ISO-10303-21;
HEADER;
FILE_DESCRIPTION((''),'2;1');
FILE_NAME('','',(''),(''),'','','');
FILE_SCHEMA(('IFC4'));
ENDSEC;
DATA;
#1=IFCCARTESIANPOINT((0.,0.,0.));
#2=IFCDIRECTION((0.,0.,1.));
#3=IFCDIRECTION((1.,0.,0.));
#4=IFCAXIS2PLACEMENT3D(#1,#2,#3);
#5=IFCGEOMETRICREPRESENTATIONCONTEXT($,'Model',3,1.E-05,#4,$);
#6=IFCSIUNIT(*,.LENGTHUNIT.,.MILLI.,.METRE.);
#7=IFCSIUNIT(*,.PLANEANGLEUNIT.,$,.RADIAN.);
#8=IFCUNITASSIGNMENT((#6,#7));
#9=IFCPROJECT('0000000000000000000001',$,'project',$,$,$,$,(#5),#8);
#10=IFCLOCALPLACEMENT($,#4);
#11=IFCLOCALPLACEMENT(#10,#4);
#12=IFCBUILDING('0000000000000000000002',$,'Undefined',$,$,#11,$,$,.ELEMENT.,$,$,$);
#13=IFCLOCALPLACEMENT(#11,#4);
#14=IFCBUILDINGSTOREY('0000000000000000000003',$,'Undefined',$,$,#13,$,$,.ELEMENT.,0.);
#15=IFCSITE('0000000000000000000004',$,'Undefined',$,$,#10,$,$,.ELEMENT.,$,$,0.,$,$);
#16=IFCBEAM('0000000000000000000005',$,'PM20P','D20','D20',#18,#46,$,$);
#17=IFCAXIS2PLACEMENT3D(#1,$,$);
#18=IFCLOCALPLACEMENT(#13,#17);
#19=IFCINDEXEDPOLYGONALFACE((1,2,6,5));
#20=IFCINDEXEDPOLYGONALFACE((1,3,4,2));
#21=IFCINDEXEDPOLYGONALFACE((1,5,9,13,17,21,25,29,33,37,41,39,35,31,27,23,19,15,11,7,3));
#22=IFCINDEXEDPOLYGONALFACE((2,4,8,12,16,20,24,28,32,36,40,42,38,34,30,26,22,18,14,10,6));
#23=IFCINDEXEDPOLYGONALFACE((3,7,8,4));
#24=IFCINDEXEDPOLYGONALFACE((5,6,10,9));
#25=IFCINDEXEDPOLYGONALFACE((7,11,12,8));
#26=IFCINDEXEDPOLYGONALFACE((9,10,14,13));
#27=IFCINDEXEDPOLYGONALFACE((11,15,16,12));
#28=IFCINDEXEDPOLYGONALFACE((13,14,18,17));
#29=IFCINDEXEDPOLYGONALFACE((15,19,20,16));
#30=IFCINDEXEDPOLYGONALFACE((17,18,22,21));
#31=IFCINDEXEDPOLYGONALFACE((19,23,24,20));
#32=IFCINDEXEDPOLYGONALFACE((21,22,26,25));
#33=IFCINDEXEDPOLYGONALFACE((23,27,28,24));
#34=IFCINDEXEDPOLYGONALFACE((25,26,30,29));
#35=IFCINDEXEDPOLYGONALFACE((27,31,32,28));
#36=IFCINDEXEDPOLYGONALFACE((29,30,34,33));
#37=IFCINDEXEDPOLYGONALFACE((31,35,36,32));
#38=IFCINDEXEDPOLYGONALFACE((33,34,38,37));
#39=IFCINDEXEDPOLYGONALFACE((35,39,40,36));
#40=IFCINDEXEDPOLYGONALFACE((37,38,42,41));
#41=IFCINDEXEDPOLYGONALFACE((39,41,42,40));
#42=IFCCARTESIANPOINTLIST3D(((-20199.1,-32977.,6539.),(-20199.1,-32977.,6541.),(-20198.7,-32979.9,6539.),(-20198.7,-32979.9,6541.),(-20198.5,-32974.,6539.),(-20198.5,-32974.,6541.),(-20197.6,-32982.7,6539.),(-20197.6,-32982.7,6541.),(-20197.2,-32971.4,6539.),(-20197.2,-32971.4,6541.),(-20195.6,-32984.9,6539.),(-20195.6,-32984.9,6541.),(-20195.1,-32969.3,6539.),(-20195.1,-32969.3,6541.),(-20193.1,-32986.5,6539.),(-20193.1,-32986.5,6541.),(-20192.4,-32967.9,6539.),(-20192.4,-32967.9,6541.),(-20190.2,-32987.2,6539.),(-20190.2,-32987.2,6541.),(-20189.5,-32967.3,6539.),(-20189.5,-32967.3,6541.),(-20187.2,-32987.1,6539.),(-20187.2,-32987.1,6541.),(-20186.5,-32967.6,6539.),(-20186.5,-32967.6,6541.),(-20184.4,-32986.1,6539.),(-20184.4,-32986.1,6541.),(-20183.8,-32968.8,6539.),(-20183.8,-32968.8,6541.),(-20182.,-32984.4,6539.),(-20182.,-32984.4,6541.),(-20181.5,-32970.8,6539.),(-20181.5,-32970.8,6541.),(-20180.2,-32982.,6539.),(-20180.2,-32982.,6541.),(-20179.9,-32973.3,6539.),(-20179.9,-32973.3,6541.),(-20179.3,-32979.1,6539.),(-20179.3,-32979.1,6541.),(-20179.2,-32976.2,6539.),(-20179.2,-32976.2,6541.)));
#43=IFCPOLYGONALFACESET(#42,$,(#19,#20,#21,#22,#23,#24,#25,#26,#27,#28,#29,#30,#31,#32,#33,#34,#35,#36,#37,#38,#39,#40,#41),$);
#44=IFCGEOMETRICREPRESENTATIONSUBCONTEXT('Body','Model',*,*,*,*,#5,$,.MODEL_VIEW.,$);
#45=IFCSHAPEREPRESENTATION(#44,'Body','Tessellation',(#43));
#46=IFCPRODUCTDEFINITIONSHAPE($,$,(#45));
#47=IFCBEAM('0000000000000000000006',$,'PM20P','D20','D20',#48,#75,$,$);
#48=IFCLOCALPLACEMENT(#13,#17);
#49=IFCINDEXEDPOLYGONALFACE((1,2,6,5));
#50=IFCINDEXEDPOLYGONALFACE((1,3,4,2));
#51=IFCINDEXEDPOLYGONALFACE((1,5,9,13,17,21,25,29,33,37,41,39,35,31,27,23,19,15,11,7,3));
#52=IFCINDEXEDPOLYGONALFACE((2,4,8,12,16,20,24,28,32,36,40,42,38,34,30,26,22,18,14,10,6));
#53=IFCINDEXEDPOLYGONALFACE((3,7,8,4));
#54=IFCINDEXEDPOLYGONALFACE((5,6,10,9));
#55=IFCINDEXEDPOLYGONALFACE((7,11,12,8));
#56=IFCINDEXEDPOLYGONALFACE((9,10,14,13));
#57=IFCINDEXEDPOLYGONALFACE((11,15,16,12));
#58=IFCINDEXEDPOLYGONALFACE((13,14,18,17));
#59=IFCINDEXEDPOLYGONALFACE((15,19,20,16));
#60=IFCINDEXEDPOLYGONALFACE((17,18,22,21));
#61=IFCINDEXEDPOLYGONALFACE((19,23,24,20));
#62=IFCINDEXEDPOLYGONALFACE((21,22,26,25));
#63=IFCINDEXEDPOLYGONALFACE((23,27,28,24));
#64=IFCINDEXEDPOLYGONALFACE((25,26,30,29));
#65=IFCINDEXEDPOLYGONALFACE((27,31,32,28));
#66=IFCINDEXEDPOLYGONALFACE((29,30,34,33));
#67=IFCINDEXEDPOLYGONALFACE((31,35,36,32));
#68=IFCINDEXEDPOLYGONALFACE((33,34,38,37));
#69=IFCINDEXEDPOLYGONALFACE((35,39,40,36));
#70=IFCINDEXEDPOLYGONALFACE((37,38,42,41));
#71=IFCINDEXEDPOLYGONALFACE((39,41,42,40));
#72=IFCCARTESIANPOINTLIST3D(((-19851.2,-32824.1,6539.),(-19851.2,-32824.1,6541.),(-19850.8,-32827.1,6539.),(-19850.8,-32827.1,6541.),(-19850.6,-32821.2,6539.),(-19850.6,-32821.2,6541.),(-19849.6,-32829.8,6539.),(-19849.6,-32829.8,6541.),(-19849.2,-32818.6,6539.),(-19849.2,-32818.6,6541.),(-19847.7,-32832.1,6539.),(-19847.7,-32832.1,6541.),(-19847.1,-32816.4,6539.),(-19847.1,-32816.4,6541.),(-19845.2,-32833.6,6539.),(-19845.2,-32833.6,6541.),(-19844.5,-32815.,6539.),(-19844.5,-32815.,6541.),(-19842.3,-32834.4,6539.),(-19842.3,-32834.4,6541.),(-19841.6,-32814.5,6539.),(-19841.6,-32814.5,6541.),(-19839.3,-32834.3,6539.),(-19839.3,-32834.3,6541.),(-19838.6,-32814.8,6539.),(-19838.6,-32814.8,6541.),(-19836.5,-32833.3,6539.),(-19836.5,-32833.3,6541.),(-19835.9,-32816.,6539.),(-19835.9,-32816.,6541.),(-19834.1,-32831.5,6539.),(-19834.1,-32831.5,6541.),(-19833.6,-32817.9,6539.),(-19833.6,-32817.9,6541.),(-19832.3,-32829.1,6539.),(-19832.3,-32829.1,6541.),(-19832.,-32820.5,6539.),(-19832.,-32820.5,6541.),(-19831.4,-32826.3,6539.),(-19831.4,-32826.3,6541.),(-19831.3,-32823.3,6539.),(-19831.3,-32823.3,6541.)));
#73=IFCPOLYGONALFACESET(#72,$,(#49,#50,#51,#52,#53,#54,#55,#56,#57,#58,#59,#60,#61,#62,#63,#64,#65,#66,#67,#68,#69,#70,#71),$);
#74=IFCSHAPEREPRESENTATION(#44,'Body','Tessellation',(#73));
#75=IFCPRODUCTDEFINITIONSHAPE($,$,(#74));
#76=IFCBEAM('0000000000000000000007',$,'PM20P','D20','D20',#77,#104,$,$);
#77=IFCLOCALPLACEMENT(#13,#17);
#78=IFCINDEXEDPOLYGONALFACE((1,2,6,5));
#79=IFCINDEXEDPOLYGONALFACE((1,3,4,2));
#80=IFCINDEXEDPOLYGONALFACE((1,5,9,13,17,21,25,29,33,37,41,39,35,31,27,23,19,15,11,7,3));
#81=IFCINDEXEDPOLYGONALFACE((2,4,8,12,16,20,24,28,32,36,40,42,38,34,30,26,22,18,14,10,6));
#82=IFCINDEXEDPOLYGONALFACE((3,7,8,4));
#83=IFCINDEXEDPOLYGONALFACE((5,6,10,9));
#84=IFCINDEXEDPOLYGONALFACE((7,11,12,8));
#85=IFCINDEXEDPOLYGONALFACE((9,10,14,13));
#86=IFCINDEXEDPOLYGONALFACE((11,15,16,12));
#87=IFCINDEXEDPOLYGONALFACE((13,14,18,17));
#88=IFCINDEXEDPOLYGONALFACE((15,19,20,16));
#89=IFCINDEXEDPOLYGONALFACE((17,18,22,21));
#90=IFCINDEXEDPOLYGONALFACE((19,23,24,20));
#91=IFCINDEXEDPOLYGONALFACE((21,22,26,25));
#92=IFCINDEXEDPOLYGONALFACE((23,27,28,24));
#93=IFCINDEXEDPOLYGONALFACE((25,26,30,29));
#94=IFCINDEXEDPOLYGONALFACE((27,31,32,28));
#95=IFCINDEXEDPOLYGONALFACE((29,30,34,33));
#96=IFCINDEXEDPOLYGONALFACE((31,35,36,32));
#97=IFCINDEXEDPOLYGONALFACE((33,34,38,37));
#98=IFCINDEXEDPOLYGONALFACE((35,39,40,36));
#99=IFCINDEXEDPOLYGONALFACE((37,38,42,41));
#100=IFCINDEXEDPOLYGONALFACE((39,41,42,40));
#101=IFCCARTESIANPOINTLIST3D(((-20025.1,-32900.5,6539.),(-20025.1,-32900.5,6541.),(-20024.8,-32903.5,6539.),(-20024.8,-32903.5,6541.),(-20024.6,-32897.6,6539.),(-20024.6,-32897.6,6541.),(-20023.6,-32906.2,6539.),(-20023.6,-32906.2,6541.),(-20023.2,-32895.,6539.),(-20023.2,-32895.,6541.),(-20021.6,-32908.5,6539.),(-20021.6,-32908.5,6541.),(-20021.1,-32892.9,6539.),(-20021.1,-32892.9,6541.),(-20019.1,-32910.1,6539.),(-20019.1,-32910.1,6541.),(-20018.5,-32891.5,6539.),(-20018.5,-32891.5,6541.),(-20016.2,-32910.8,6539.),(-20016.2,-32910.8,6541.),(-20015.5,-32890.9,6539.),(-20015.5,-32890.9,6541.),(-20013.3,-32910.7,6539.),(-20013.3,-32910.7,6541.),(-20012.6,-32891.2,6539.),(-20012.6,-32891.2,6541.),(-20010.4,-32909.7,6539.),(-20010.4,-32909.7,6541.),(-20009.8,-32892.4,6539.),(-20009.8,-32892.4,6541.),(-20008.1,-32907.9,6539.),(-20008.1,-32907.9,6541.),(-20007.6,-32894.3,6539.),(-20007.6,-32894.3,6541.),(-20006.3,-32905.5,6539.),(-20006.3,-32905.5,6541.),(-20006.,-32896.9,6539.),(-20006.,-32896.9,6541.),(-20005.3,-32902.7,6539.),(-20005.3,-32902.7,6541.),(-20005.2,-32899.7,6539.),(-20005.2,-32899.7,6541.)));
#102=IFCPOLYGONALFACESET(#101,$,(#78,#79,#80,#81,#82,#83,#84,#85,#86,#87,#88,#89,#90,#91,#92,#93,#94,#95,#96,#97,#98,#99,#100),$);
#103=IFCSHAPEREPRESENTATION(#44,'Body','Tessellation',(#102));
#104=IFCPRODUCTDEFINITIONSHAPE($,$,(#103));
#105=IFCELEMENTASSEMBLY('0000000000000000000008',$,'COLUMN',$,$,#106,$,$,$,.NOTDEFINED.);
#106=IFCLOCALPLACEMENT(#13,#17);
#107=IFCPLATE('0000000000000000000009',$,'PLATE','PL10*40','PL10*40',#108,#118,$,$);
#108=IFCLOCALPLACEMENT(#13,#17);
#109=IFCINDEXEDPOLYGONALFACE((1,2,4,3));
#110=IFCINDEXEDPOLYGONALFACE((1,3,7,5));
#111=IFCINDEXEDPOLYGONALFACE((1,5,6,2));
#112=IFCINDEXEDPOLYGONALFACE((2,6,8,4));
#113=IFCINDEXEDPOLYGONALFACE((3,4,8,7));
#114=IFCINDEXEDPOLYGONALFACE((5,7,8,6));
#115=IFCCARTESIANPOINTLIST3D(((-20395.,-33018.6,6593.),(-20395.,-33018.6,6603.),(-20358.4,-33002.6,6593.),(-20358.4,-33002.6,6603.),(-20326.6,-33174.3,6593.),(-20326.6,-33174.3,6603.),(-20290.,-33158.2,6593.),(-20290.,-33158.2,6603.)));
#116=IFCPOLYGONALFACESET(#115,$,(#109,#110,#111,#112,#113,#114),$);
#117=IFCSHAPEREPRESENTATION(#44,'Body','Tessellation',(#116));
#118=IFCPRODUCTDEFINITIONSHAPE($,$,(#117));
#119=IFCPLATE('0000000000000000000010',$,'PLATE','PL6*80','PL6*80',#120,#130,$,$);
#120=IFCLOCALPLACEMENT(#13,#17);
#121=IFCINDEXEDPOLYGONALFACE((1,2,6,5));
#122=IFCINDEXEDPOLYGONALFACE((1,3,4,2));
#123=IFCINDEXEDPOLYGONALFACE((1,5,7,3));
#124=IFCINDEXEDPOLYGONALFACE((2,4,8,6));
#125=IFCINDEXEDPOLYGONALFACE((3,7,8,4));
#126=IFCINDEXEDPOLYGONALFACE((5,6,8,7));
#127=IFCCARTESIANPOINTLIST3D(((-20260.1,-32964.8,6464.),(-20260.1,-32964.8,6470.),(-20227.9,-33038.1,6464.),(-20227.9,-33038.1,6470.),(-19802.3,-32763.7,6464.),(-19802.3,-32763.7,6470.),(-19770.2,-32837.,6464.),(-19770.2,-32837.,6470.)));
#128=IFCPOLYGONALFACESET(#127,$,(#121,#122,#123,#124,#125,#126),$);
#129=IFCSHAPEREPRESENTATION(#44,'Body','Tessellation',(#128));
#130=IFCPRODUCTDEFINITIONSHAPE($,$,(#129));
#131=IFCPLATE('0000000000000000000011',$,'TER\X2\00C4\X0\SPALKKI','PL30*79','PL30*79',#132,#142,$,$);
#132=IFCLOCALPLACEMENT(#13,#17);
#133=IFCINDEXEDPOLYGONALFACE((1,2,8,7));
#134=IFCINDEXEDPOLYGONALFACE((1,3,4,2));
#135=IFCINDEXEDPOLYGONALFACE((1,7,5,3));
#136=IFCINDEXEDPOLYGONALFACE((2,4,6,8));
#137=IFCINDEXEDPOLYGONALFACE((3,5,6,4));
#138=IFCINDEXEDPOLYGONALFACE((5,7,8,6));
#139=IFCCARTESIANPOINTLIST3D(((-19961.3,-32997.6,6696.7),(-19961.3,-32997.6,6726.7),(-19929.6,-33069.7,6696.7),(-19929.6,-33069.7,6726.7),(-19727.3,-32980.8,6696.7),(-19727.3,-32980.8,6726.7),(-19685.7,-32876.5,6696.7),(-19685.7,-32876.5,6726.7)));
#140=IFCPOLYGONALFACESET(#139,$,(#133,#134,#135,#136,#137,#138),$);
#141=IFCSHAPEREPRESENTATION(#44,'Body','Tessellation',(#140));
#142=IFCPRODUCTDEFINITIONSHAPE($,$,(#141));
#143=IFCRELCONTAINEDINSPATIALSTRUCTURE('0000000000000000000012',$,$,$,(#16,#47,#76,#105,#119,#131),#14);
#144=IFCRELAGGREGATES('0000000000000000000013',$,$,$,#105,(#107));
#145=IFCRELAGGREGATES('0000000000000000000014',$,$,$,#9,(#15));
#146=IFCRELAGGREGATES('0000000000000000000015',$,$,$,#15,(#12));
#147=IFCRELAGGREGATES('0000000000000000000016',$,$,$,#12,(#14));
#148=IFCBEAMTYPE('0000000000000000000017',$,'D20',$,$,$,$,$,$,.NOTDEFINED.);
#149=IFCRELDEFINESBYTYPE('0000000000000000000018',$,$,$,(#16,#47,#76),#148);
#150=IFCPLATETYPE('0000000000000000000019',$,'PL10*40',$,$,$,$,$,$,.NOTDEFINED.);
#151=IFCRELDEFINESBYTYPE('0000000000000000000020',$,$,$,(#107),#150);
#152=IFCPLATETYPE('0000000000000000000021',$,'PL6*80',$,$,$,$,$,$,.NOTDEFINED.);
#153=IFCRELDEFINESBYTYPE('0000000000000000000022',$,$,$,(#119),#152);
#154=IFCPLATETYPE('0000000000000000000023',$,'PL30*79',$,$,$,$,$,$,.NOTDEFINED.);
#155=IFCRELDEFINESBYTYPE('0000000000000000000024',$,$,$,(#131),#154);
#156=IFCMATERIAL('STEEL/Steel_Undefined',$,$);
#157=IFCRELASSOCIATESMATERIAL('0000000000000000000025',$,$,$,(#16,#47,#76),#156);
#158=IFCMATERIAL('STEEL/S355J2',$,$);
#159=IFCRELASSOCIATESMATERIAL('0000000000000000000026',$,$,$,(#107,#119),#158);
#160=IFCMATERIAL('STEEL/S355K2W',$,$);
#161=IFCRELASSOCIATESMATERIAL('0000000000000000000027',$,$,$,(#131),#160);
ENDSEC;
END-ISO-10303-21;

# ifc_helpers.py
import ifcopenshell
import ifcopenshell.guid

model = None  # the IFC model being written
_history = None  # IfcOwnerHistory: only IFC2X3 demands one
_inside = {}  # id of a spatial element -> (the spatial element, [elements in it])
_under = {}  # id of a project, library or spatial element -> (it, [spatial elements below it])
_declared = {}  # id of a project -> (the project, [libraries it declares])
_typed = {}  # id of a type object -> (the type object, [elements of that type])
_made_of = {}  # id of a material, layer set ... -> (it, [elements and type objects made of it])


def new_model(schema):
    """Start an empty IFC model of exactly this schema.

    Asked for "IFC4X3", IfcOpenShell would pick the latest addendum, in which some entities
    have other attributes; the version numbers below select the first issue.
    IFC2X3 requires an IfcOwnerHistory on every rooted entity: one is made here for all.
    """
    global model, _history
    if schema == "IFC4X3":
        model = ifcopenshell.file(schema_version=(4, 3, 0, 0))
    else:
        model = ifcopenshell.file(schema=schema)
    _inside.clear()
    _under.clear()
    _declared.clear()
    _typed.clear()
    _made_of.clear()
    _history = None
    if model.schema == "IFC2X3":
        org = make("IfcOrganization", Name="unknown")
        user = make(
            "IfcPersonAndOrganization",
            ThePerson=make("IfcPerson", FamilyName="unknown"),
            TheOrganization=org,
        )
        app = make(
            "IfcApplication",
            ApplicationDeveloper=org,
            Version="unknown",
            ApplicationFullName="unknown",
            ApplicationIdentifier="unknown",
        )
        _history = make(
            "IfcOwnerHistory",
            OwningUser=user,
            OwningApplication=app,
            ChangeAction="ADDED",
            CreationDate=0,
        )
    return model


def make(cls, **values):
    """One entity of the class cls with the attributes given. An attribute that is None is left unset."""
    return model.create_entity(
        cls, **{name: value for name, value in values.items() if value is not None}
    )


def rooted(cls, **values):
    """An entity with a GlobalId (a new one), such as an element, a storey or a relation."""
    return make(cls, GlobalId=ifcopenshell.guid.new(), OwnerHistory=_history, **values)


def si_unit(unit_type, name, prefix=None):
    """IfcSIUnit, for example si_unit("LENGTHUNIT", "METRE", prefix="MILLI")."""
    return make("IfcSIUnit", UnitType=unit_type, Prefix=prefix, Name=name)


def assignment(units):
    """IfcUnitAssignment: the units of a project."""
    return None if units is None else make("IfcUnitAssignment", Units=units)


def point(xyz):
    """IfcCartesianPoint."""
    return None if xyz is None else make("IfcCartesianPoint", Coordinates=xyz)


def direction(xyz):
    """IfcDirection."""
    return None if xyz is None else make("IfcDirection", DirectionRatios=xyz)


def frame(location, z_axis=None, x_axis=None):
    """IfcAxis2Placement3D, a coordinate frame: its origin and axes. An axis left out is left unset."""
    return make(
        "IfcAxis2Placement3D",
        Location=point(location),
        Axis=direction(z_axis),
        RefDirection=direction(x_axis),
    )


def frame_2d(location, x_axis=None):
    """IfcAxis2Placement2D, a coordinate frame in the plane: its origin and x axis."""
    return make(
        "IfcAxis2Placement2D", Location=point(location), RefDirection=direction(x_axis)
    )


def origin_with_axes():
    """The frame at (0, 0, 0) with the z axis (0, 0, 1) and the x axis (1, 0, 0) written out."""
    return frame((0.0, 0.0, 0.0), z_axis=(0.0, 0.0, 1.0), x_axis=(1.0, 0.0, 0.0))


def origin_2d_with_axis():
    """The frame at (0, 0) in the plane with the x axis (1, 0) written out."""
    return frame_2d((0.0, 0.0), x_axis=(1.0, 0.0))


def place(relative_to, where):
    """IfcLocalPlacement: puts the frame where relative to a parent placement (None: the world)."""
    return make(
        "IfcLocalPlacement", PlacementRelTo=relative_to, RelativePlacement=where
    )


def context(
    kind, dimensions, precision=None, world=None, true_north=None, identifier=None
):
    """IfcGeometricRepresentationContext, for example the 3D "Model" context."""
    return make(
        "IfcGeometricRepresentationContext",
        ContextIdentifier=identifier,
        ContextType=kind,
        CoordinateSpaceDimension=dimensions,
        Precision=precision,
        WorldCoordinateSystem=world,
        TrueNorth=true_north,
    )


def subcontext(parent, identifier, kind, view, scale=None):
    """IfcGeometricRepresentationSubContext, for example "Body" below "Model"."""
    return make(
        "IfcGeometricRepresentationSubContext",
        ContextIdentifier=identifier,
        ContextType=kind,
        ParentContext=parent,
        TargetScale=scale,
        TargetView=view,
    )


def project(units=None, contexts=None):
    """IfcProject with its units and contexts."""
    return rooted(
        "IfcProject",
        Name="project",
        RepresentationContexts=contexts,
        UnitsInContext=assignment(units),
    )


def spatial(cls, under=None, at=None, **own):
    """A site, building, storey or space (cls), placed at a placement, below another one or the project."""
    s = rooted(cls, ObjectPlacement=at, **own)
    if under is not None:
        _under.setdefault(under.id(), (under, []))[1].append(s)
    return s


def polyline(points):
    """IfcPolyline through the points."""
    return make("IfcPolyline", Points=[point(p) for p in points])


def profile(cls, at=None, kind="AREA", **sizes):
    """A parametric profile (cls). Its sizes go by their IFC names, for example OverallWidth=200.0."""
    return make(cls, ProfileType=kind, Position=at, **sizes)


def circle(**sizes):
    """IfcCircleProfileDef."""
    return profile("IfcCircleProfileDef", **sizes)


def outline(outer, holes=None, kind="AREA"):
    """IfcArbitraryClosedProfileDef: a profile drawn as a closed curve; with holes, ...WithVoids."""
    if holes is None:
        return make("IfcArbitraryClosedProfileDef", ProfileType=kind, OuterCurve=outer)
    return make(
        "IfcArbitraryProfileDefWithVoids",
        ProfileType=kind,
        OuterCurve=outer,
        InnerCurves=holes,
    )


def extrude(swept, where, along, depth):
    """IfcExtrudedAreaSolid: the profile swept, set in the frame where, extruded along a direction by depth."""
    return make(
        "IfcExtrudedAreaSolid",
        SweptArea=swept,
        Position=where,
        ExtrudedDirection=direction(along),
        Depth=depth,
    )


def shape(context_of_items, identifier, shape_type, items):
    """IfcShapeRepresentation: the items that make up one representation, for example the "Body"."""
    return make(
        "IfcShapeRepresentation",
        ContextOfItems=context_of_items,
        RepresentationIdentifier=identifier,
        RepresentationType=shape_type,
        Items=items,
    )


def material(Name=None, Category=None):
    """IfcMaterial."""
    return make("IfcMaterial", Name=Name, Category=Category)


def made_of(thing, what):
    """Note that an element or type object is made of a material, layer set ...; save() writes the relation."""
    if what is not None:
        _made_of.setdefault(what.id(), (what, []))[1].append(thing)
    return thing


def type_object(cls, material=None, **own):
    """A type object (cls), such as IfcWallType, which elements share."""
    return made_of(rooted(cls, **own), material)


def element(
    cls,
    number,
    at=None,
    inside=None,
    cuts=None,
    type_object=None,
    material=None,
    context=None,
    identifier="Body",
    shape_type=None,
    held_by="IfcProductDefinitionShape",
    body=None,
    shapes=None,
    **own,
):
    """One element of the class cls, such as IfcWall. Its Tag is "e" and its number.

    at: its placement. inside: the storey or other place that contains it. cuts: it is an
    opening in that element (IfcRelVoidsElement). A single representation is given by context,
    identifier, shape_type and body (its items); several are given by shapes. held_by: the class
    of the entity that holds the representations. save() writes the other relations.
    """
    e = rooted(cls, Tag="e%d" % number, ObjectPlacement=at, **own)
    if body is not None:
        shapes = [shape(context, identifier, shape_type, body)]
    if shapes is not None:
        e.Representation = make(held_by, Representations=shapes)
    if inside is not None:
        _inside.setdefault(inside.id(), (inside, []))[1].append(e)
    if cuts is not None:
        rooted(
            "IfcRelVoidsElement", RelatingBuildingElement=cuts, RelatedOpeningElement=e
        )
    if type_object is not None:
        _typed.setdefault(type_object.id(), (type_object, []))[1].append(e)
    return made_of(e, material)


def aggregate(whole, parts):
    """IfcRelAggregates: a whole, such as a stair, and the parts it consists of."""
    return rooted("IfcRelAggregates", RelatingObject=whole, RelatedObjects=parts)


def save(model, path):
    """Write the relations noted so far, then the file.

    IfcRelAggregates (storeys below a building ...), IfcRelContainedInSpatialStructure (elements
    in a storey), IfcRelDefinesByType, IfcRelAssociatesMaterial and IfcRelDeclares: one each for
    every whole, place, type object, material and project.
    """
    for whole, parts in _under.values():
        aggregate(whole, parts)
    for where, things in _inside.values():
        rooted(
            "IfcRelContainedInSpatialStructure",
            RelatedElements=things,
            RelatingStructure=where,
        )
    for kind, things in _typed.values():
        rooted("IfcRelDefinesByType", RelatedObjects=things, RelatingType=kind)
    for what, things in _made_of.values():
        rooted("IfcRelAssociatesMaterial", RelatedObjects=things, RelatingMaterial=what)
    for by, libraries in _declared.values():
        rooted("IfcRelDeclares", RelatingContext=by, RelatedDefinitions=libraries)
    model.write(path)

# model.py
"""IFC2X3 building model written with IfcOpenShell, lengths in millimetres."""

from ifc_helpers import new_model, si_unit, frame, origin_with_axes, origin_2d_with_axis, place, context, subcontext, project, spatial, polyline, circle, outline, extrude, material, type_object, element, aggregate, save


model = new_model("IFC2X3")

# Units and contexts
model_context = context("Model", 3, precision=1e-05, world=origin_with_axes())
body_context = subcontext(model_context, "Body", "Model", "MODEL_VIEW")
ifc_project = project(units=[si_unit("LENGTHUNIT", "METRE", prefix="MILLI"), si_unit("PLANEANGLEUNIT", "RADIAN")], contexts=[model_context])

# Site, building, storey
site_placement = place(None, origin_with_axes())
site = spatial("IfcSite", under=ifc_project, at=site_placement, Name="Undefined", CompositionType="ELEMENT", RefElevation=0.0)
building_placement = place(site_placement, origin_with_axes())
building = spatial("IfcBuilding", under=site, at=building_placement, Name="Undefined", CompositionType="ELEMENT")
storey_placement = place(building_placement, origin_with_axes())
storey = spatial("IfcBuildingStorey", under=building, at=storey_placement, Name="Undefined", CompositionType="ELEMENT", Elevation=0.0)

# Beams
ifc_material_1 = material(Name="STEEL/Steel_Undefined")
beam_type_1 = type_object("IfcBeamType", Name="D20", PredefinedType="NOTDEFINED")
for number, where, z_axis, x_axis, name in (
    (1, (-20189.1, -32977.3, 6541.0), (-0.402199, 0.915552, 0.0), (0.0, 0.0, -1.0), "PM20P"),
    (2, (-19841.2, -32824.5, 6541.0), (-0.402199, 0.915552, 0.0), (0.0, 0.0, -1.0), "PM20P"),
    (3, (-20015.1, -32900.9, 6541.0), (-0.402199, 0.915552, 0.0), (0.0, 0.0, -1.0), "PM20P"),
):
    element("IfcBeam", number, at=place(storey_placement, frame(where, z_axis=z_axis, x_axis=x_axis)), inside=storey, type_object=beam_type_1, material=ifc_material_1, Name=name, Description="D20", ObjectType="D20", context=body_context, shape_type="SweptSolid", body=[
        extrude(circle(Radius=10.0, at=origin_2d_with_axis()), frame((2.0, 0.0, 0.0), z_axis=(-1.0, 0.0, 0.0), x_axis=(0.0, -1.0, 0.0)), (0.0, 0.0, 1.0), 2.0),
    ])

# Element assembly, plate
assembly_placement = place(storey_placement, frame((-20342.6, -33088.4, 6133.0), z_axis=(-0.736465, 0.676475, 0.0), x_axis=(0.0, 0.0, 1.0)))
assembly = element("IfcElementAssembly", 4, at=assembly_placement, inside=storey, Name="COLUMN", PredefinedType="NOTDEFINED")
ifc_material_2 = material(Name="STEEL/S355J2")
plate_type_1 = type_object("IfcPlateType", Name="PL10*40", PredefinedType="NOTDEFINED")
plate_1_placement = place(storey_placement, frame((-20395.0, -33018.6, 6598.0), z_axis=(0.0, 0.0, 1.0), x_axis=(0.402197, -0.915553, 0.0)))
plate_1 = element("IfcPlate", 5, at=plate_1_placement, type_object=plate_type_1, material=ifc_material_2, Name="PLATE", Description="PL10*40", ObjectType="PL10*40", context=body_context, shape_type="SweptSolid", body=[
    extrude(outline(polyline([(0.0, 0.0), (170.0, 0.0), (170.0, 40.0), (0.0, 40.0), (0.0, 0.0)])), frame((0.0, 0.0, -5.0), z_axis=(0.0, 0.0, 1.0), x_axis=(1.0, 0.0, 0.0)), (0.0, 0.0, 1.0), 10.0),
])
aggregate(assembly, [plate_1])

# Plates
plate_type_2 = type_object("IfcPlateType", Name="PL6*80", PredefinedType="NOTDEFINED")
plate_2_placement = place(storey_placement, frame((-20260.1, -32964.8, 6467.0), z_axis=(0.0, 0.0, 1.0), x_axis=(0.402199, -0.915552, 0.0)))
element("IfcPlate", 6, at=plate_2_placement, inside=storey, type_object=plate_type_2, material=ifc_material_2, Name="PLATE", Description="PL6*80", ObjectType="PL6*80", context=body_context, shape_type="SweptSolid", body=[
    extrude(outline(polyline([(0.0, 0.0), (80.0, 0.0), (80.0, 500.0), (0.0, 500.0), (0.0, 0.0)])), frame((0.0, 0.0, -3.0), z_axis=(0.0, 0.0, 1.0), x_axis=(1.0, 0.0, 0.0)), (0.0, 0.0, 1.0), 6.0),
])
ifc_material_3 = material(Name="STEEL/S355K2W")
plate_type_3 = type_object("IfcPlateType", Name="PL30*79", PredefinedType="NOTDEFINED")
plate_3_placement = place(storey_placement, frame((-19929.6, -33069.7, 6711.7), z_axis=(0.0, 0.0, 1.0), x_axis=(0.915556, 0.40219, 0.0)))
element("IfcPlate", 7, at=plate_3_placement, inside=storey, type_object=plate_type_3, material=ifc_material_3, Name="TERÄSPALKKI", Description="PL30*79", ObjectType="PL30*79", context=body_context, shape_type="SweptSolid", body=[
    extrude(outline(polyline([(0.0, 0.0), (221.0, 0.0), (301.0, 78.7), (0.0, 78.7), (0.0, 0.0)])), frame((0.0, 0.0, -15.0), z_axis=(0.0, 0.0, 1.0), x_axis=(1.0, 0.0, 0.0)), (0.0, 0.0, 1.0), 30.0),
])

save(model, "model.ifc")
